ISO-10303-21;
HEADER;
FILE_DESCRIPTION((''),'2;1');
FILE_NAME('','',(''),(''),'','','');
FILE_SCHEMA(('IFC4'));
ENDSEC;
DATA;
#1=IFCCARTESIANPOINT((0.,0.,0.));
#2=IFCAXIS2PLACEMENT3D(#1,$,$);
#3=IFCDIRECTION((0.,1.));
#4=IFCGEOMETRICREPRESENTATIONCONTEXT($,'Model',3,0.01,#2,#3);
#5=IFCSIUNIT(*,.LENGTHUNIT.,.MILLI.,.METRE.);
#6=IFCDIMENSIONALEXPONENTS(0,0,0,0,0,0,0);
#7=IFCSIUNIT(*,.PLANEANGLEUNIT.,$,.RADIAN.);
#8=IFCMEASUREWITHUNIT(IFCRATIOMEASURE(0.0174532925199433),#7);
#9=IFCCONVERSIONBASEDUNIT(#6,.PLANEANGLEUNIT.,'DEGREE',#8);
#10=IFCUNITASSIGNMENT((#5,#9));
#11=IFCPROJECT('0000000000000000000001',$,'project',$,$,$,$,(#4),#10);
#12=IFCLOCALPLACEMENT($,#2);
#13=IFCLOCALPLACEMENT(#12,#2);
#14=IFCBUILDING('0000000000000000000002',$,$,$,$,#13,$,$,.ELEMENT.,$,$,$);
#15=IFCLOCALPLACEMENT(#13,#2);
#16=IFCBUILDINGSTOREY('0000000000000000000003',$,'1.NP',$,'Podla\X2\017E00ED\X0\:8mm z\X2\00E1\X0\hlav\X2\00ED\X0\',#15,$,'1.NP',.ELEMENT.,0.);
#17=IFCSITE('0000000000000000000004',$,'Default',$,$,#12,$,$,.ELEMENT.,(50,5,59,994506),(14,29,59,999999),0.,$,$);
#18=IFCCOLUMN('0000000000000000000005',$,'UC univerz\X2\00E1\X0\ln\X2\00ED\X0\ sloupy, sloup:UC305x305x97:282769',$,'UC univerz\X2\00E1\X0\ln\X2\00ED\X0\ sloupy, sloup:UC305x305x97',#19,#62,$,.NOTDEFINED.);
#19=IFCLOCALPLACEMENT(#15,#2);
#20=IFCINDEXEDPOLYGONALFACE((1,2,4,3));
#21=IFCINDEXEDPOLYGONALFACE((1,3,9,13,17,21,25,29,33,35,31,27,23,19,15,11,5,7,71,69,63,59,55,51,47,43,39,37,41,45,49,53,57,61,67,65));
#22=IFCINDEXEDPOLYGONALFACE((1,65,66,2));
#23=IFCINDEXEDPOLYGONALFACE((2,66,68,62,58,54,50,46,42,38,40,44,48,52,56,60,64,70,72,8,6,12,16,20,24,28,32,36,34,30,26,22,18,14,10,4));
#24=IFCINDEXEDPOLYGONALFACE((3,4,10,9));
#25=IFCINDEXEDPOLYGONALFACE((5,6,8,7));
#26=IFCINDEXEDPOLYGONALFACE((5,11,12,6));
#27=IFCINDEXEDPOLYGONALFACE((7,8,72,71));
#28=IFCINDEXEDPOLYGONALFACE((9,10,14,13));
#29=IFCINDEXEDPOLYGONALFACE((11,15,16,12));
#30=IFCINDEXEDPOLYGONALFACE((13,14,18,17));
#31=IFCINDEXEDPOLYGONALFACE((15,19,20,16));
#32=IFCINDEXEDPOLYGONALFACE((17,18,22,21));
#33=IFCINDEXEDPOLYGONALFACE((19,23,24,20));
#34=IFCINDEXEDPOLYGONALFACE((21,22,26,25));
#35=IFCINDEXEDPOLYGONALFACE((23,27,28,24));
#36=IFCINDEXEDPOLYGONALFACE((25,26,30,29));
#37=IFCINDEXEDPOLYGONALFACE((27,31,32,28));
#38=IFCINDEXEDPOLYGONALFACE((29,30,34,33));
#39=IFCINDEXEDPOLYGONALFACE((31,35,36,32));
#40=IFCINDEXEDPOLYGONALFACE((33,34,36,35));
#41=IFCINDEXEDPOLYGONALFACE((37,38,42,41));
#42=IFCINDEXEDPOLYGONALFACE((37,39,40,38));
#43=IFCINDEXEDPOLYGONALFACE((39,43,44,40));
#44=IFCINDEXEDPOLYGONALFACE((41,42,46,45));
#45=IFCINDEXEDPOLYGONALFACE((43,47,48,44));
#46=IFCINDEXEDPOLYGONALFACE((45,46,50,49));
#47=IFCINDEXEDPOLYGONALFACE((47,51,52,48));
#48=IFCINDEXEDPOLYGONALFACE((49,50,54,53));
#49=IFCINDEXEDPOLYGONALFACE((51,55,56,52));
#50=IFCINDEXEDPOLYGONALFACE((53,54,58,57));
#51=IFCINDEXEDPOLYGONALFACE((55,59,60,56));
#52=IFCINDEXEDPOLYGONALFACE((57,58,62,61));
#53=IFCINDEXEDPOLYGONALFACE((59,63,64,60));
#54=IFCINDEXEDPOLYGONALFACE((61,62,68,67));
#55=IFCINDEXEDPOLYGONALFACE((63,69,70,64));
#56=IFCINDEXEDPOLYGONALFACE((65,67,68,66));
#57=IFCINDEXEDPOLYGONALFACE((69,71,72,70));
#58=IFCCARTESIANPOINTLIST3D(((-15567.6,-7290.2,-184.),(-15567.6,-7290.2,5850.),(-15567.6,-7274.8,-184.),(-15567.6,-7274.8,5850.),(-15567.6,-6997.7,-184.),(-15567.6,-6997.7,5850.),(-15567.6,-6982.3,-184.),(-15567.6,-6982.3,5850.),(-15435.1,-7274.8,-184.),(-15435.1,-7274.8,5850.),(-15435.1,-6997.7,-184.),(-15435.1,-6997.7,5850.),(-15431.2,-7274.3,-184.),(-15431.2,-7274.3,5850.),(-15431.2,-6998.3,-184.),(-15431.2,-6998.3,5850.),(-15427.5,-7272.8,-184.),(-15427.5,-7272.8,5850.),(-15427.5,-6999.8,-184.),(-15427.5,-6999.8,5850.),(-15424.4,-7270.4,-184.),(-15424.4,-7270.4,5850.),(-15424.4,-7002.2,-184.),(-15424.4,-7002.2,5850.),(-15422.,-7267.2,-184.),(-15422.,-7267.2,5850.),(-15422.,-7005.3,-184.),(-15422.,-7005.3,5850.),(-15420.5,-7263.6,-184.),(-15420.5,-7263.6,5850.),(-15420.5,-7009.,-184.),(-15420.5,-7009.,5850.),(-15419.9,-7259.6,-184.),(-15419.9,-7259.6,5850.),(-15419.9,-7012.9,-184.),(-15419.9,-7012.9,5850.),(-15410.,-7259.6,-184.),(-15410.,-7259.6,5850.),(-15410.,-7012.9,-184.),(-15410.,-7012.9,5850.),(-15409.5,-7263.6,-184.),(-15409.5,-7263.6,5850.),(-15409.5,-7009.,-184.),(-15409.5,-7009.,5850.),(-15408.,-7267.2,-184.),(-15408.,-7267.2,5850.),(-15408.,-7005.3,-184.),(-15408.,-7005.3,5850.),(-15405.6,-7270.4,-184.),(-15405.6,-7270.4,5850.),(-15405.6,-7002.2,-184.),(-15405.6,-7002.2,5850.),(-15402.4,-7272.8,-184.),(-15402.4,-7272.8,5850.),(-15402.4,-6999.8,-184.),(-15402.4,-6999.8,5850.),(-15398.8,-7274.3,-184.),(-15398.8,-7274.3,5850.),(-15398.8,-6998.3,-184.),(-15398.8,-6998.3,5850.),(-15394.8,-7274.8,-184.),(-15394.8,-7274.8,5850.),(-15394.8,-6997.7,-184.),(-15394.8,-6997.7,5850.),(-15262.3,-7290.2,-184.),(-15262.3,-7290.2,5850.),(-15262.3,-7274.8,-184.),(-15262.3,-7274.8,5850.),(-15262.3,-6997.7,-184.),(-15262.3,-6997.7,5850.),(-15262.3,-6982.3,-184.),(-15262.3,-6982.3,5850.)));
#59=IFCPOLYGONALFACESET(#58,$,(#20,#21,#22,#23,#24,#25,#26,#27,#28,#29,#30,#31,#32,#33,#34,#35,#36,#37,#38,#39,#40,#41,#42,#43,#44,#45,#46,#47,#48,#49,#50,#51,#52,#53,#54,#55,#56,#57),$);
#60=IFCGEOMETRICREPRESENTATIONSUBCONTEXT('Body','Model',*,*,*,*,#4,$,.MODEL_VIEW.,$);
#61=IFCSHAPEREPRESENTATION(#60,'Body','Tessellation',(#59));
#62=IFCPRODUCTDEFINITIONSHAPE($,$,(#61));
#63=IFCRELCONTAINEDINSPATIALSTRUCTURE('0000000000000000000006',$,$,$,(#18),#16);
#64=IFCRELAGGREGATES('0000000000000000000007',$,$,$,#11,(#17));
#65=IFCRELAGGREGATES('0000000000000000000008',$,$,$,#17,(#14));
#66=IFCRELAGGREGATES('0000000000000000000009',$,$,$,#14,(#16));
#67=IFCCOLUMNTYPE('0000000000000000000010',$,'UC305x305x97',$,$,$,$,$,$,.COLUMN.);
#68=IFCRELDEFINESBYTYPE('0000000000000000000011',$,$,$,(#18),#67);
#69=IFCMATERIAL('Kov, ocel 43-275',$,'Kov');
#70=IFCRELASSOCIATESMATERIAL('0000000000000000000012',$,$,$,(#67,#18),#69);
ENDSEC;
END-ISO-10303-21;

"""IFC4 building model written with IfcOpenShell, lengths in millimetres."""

from ifc_helpers import new_model, entity, si_unit, converted_unit, direction, frame, frame_2d, origin, place, context, subcontext, project, spatial, i_section, extrude, source, transform, mapped, material, material_profile, profile_set, profile_usage, type_object, type_shapes, element, save


model = new_model("IFC4")

# Units and contexts
model_context = context("Model", 3, precision=0.01, world=origin(), true_north=direction((0.0, 1.0)))
body_context = subcontext(model_context, "Body", "Model", "MODEL_VIEW")
ifc_project = project(units=[si_unit("LENGTHUNIT", "METRE", prefix="MILLI"), converted_unit("PLANEANGLEUNIT", "DEGREE", entity("IfcRatioMeasure", 0.0174532925199433), si_unit("PLANEANGLEUNIT", "RADIAN"), dimensions=[0, 0, 0, 0, 0, 0, 0])], contexts=[model_context])

# Site, building, storey
site_placement = place(None, origin())
site = spatial("IfcSite", under=ifc_project, at=site_placement, Name="Default", CompositionType="ELEMENT", RefLatitude=(50, 5, 59, 994506), RefLongitude=(14, 29, 59, 999999), RefElevation=0.0)
building_placement = place(site_placement, origin())
building = spatial("IfcBuilding", under=site, at=building_placement, CompositionType="ELEMENT")
storey_placement = place(building_placement, origin())
storey = spatial("IfcBuildingStorey", under=building, at=storey_placement, Name="1.NP", ObjectType="Podlaží:8mm záhlaví", LongName="1.NP", CompositionType="ELEMENT", Elevation=0.0)

# Column
ifc_material_1 = material(Name="Kov, ocel 43-275", Category="Kov")
ifc_material_profile = material_profile(ifc_material_1, i_section(OverallWidth=305.3, OverallDepth=307.9, WebThickness=9.9, FlangeThickness=15.4, FilletRadius=15.2, at=frame_2d((0.0, 0.0), x_axis=(0.0, 1.0))), Name="UC305x305x97")
ifc_profile_set = profile_set([ifc_material_profile], Name="UC305x305x97")
ifc_profile_usage = profile_usage(ifc_profile_set)
column_type = type_object("IfcColumnType", Name="UC305x305x97", PredefinedType="COLUMN", material=ifc_profile_set)
shared_shape_1 = source(origin(), body_context, "Body", "SweptSolid", [
    extrude(i_section(OverallWidth=305.3, OverallDepth=307.9, WebThickness=9.9, FlangeThickness=15.4, FilletRadius=15.2, at=frame_2d((0.0, 0.0), x_axis=(0.0, 1.0))), frame((0.0, 0.0, -184.0), z_axis=(0.0, 0.0, 1.0), x_axis=(0.0, -1.0, 0.0)), (0.0, 0.0, 1.0), 6034.0),
])
type_shapes(column_type, [shared_shape_1])
column_placement = place(storey_placement, frame((-15415.0, -7136.3, 0.0)))
element("IfcColumn", 1, at=column_placement, inside=storey, type_object=column_type, material=ifc_profile_usage, Name="UC univerzální sloupy, sloup:UC305x305x97:282769", ObjectType="UC univerzální sloupy, sloup:UC305x305x97", PredefinedType="NOTDEFINED", context=body_context, shape_type="MappedRepresentation", body=[
    mapped(shared_shape_1, transform((0.0, 0.0, 0.0), scale=1.0)),
])

save(model, "model.ifc")
